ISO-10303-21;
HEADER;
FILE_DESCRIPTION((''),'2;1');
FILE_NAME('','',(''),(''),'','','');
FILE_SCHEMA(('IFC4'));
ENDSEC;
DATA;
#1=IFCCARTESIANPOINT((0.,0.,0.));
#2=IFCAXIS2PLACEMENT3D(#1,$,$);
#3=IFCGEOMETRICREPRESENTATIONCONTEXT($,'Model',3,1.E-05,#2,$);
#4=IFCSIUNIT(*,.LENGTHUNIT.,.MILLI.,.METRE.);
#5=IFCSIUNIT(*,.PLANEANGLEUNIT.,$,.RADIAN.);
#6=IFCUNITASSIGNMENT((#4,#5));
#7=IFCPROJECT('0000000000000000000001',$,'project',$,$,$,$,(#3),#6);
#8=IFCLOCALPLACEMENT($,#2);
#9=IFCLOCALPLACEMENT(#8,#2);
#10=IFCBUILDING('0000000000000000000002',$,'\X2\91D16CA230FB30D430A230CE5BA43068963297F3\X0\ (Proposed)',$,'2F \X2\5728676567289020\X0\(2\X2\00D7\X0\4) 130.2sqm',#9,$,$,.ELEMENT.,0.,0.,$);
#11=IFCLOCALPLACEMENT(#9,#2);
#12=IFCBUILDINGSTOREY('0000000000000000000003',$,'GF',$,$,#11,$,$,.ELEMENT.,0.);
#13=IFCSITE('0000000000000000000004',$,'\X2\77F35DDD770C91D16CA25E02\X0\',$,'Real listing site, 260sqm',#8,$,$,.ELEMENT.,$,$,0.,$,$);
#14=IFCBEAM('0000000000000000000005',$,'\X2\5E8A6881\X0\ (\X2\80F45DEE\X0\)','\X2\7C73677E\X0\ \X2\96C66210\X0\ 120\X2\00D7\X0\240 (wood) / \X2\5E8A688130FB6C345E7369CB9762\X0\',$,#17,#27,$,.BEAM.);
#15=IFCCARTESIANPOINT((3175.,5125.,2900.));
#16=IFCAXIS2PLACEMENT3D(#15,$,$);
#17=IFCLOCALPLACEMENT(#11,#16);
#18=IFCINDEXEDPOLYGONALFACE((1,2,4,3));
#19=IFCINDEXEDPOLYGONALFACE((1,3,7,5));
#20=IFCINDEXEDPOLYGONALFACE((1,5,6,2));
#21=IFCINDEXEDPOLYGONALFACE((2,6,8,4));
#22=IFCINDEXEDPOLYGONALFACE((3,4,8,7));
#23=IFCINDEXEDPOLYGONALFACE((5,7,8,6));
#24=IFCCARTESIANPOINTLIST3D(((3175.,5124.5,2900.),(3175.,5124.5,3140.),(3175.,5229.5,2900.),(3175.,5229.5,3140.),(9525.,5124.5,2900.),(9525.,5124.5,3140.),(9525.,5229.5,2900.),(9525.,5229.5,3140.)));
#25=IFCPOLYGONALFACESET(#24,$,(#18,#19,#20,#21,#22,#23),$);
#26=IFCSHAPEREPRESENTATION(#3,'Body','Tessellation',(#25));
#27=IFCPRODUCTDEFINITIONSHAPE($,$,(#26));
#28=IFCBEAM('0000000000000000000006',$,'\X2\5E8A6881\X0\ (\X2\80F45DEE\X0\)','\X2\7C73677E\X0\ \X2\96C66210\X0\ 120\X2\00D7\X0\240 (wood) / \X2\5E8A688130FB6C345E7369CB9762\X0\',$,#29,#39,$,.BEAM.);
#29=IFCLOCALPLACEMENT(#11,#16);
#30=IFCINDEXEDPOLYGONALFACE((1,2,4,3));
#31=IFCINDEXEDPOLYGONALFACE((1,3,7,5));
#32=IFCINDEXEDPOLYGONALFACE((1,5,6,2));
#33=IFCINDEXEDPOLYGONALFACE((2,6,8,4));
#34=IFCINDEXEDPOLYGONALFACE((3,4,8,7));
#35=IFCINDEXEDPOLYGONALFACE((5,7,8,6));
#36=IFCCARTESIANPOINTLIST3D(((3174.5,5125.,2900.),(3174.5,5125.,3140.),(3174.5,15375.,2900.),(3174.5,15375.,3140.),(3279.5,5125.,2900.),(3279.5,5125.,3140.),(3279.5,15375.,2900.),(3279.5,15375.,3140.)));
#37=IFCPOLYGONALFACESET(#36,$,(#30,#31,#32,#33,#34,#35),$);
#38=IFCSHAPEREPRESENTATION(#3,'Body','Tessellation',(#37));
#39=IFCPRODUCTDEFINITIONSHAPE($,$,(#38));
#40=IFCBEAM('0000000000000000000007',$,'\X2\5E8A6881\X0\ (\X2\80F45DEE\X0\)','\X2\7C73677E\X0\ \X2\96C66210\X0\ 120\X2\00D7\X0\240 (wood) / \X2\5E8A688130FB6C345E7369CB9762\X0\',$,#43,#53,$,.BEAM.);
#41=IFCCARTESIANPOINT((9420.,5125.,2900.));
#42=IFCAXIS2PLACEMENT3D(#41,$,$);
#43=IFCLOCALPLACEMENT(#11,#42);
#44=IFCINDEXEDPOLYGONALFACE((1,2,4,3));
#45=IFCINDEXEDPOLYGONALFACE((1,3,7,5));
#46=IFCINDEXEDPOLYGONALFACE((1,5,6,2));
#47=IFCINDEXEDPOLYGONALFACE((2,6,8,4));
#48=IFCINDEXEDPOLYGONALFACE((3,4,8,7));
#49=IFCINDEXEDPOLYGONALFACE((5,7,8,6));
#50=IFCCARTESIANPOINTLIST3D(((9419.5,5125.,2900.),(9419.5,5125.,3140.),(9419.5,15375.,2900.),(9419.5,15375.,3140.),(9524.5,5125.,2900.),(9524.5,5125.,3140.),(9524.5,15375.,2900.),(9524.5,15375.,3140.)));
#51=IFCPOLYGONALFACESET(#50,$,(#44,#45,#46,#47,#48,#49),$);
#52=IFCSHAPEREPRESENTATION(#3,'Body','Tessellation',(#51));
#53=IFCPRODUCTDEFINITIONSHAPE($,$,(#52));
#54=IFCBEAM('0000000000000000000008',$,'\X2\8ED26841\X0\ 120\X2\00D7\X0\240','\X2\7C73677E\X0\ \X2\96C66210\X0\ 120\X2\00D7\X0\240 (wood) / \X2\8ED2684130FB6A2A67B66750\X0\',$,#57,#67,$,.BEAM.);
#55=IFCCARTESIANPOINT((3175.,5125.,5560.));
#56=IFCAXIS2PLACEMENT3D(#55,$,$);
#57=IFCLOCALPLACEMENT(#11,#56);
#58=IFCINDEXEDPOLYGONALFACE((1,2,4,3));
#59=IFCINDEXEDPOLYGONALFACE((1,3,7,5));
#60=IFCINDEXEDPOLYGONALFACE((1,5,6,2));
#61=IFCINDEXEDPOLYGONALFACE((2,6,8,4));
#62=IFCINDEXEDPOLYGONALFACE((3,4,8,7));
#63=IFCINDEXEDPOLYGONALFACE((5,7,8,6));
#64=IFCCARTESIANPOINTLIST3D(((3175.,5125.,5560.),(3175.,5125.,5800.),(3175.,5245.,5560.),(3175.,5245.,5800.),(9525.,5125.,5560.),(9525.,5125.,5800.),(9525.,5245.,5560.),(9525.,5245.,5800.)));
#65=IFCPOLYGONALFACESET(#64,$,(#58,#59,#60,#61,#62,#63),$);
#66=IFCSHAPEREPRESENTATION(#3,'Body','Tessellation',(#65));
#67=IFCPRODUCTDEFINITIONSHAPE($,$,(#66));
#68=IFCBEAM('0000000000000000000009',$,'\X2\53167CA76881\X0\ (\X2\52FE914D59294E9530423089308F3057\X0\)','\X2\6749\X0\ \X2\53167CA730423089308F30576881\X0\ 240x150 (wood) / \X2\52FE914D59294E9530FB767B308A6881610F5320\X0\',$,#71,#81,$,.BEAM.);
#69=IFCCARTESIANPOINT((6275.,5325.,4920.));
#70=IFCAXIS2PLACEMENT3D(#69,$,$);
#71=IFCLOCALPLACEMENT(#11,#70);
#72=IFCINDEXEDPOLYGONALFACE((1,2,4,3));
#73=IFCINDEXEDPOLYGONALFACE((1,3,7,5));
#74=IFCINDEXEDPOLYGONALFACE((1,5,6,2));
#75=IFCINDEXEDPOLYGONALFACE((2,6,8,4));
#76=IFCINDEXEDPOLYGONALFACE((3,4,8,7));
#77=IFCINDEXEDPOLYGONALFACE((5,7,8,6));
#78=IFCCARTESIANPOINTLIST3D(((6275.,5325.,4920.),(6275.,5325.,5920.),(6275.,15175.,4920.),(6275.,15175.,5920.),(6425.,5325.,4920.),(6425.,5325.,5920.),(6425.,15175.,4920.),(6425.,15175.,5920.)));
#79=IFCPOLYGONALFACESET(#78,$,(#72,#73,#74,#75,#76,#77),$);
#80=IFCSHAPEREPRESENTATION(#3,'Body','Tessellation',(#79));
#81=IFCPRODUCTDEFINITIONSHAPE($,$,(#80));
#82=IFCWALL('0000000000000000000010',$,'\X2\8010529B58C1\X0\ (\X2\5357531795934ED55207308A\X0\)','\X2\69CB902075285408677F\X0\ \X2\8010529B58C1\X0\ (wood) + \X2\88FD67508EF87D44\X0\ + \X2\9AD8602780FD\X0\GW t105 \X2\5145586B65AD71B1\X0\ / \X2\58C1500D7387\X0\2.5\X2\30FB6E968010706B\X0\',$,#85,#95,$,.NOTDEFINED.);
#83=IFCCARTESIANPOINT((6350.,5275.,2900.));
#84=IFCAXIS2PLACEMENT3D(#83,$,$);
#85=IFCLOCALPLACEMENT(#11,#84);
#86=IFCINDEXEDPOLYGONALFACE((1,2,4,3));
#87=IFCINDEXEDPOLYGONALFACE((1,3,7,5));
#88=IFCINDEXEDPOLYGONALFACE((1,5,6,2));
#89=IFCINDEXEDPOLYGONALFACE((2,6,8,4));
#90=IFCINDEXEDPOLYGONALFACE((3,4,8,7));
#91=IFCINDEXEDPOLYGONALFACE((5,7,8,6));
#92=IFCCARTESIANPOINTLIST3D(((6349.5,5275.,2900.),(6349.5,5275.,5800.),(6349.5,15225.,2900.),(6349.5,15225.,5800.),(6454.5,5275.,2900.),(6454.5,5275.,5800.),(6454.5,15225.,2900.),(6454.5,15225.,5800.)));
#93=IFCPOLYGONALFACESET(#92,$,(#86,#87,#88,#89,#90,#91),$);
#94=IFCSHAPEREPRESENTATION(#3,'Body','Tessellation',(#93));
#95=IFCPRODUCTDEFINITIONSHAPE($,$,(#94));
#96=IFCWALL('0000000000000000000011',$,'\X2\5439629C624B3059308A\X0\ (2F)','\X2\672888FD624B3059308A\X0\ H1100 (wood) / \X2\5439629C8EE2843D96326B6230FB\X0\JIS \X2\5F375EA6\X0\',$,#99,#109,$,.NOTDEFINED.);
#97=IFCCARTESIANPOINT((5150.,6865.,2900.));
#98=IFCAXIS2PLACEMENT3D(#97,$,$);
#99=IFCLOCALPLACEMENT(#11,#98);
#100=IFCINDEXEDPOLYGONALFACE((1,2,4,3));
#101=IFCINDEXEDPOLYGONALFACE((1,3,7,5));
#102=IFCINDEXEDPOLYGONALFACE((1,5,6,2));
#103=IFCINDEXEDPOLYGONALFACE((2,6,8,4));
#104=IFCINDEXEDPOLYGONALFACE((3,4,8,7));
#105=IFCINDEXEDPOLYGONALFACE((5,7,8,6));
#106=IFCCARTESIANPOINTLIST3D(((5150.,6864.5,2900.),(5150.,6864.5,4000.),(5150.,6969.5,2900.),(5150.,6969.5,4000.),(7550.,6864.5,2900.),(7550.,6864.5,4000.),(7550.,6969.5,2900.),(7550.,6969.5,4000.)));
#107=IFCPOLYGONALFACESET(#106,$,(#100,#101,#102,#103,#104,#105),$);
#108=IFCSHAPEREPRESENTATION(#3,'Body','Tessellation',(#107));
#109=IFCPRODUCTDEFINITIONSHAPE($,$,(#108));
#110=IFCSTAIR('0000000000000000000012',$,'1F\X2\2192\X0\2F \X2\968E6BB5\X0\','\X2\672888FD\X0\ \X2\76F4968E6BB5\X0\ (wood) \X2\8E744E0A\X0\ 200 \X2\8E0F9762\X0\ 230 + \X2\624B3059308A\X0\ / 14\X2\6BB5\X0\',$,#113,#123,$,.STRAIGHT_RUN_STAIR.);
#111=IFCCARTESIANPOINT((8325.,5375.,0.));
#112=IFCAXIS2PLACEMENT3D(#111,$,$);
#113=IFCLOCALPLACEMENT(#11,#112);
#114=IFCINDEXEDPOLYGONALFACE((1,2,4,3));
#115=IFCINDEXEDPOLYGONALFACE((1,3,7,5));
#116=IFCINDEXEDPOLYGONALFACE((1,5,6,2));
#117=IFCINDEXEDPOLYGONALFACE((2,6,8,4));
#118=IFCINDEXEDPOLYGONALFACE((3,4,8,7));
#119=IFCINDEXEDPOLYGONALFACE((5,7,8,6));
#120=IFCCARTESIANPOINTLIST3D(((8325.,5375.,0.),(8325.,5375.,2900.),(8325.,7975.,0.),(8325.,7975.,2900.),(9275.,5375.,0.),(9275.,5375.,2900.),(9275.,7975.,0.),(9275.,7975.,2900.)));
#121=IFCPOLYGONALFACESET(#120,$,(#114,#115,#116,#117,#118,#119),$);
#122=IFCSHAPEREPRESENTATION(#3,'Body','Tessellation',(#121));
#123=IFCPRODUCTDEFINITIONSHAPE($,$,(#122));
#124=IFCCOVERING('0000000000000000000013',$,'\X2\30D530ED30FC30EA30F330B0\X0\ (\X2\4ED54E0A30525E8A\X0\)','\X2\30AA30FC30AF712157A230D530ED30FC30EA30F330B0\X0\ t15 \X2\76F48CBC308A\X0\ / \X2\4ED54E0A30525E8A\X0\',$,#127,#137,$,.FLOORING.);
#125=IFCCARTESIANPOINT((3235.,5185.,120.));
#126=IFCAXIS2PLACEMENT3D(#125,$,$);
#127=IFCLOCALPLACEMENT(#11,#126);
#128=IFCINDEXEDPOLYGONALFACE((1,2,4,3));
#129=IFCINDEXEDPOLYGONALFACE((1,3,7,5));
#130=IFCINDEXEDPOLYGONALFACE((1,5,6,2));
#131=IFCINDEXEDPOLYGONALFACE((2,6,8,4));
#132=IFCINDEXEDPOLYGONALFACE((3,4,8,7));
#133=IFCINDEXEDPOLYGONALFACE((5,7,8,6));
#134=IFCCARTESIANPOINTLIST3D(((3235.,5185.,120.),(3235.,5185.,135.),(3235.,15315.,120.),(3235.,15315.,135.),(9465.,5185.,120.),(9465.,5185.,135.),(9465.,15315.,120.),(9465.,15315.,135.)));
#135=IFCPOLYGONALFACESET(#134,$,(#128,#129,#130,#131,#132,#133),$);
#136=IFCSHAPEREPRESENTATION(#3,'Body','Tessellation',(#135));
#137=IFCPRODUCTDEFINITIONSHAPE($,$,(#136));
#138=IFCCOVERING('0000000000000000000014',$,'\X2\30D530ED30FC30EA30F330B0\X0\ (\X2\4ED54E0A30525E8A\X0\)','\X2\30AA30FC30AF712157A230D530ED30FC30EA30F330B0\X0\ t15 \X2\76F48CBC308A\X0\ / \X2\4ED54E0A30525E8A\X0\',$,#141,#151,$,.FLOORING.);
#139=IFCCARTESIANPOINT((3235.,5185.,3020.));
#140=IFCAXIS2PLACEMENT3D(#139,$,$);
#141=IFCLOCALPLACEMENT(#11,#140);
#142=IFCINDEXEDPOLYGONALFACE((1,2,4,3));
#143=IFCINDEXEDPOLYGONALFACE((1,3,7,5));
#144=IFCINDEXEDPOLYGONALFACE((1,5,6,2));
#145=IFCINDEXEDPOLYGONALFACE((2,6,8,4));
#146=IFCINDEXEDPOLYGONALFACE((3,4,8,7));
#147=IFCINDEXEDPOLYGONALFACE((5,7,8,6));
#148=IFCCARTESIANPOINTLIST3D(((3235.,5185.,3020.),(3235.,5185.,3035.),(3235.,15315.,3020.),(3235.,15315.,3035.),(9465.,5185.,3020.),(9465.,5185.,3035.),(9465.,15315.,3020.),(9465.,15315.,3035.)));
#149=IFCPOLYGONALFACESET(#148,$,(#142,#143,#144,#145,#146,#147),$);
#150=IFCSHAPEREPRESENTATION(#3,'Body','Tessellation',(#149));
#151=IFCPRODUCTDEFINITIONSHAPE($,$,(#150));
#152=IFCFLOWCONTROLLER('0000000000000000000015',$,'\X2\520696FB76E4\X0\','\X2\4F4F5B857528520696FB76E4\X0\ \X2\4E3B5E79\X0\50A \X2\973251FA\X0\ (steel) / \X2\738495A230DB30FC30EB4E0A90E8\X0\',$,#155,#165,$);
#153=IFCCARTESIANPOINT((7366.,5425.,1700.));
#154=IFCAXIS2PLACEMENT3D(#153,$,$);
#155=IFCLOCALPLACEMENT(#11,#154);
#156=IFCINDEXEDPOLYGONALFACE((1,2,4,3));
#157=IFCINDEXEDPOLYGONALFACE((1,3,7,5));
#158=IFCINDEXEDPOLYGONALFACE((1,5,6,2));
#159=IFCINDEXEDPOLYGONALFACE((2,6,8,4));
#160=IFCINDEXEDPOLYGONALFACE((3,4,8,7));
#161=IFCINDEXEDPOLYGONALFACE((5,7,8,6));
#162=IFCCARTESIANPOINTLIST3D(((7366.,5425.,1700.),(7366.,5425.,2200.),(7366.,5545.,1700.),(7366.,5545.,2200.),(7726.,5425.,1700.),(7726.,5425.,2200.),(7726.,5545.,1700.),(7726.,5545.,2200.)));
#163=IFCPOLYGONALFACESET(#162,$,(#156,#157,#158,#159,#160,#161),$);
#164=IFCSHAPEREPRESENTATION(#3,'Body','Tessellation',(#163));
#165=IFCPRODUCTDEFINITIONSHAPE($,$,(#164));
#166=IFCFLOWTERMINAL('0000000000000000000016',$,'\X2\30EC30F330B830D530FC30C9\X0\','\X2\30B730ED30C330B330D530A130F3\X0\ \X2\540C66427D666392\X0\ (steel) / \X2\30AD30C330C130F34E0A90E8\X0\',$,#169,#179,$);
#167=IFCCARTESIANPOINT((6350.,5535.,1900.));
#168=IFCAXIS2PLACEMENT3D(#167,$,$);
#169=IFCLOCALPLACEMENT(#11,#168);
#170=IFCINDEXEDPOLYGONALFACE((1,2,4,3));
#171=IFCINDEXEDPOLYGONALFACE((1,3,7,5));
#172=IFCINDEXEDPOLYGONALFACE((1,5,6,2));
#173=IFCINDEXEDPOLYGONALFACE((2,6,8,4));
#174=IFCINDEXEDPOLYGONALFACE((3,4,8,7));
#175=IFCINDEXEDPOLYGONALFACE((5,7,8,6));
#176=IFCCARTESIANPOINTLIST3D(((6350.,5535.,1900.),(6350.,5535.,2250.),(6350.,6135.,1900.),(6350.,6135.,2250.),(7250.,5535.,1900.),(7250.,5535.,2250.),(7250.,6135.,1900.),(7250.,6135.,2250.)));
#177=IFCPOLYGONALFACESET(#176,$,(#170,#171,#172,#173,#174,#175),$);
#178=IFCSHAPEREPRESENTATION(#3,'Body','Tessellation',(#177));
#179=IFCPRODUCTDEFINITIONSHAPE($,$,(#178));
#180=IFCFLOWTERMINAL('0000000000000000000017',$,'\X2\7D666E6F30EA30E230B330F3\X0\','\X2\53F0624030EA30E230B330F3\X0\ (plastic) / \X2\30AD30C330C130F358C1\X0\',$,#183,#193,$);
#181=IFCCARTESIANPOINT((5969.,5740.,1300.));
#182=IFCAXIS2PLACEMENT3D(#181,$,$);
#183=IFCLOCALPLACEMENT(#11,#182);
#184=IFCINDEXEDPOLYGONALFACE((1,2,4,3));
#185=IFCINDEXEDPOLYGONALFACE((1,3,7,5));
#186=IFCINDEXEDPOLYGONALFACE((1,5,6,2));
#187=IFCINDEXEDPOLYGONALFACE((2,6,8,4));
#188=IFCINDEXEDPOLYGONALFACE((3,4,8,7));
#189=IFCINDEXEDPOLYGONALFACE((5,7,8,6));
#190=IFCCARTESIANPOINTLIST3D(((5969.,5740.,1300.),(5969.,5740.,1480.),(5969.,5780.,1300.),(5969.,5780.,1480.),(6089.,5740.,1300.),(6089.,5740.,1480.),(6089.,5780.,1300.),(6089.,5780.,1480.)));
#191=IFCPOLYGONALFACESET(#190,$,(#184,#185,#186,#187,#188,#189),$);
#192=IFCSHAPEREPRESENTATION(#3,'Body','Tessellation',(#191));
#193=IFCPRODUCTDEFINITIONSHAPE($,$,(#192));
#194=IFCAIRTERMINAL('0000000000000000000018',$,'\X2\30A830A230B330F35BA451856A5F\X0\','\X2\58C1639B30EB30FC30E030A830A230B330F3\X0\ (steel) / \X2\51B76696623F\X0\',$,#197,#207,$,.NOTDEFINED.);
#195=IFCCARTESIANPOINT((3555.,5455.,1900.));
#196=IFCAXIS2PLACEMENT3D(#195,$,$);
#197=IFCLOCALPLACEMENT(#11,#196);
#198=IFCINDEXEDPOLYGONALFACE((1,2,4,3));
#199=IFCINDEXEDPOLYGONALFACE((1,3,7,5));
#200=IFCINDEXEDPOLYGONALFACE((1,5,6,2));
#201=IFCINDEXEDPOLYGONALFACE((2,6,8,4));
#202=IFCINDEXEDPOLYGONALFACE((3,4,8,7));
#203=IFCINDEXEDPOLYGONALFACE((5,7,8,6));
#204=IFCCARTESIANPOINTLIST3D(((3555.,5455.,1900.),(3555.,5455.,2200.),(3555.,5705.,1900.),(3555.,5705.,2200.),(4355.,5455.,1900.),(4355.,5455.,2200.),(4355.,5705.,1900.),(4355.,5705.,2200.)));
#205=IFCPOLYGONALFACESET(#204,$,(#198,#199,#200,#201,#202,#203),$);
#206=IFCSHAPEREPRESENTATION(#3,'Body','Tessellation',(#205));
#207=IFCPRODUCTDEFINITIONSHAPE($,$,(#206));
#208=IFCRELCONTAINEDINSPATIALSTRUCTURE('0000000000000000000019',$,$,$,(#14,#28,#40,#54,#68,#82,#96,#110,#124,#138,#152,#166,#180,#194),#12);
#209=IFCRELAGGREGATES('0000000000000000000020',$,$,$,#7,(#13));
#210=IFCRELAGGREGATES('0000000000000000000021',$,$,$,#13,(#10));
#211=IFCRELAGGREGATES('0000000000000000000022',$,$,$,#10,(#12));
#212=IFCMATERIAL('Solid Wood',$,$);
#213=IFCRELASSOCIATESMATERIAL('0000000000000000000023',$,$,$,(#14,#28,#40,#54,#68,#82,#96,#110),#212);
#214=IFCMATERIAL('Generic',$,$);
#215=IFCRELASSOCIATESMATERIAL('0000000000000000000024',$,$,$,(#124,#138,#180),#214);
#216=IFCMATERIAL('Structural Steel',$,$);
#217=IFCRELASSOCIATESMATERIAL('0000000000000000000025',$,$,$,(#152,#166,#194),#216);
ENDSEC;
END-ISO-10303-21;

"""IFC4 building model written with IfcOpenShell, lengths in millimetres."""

from ifc_helpers import new_model, si_unit, frame, frame_2d, origin, place, context, project, spatial, rectangle, extrude, material, element, save


model = new_model("IFC4")

# Units and contexts
model_context = context("Model", 3, precision=1e-05, world=origin())
ifc_project = project(units=[si_unit("LENGTHUNIT", "METRE", prefix="MILLI"), si_unit("PLANEANGLEUNIT", "RADIAN")], contexts=[model_context])

# Site, building, storey
site_placement = place(None, origin())
site = spatial("IfcSite", under=ifc_project, at=site_placement, Name="石川県金沢市", ObjectType="Real listing site, 260sqm", CompositionType="ELEMENT", RefElevation=0.0)
building_placement = place(site_placement, origin())
building = spatial("IfcBuilding", under=site, at=building_placement, Name="金沢・ピアノ室と防音 (Proposed)", ObjectType="2F 在来木造(2×4) 130.2sqm", CompositionType="ELEMENT", ElevationOfRefHeight=0.0, ElevationOfTerrain=0.0)
storey_placement = place(building_placement, origin())
storey = spatial("IfcBuildingStorey", under=building, at=storey_placement, Name="GF", CompositionType="ELEMENT", Elevation=0.0)

# Shared definitions
ifc_material_1 = material(Name="Solid Wood")

# Beams
beam_1_placement = place(storey_placement, frame((3175.0, 5125.0, 2900.0)))
element("IfcBeam", 1, at=beam_1_placement, inside=storey, material=ifc_material_1, Name="床梁 (胴差)", Description="米松 集成 120×240 (wood) / 床梁・水平構面", PredefinedType="BEAM", context=model_context, shape_type="SweptSolid", body=[
    extrude(rectangle(XDim=6350.0, YDim=105.0, at=frame_2d((3175.0, 52.0))), frame((3175.0, 5125.0, 2900.0)), (0.0, 0.0, 1.0), 240.0),
])
beam_2_placement = place(storey_placement, frame((3175.0, 5125.0, 2900.0)))
element("IfcBeam", 2, at=beam_2_placement, inside=storey, material=ifc_material_1, Name="床梁 (胴差)", Description="米松 集成 120×240 (wood) / 床梁・水平構面", PredefinedType="BEAM", context=model_context, shape_type="SweptSolid", body=[
    extrude(rectangle(XDim=105.0, YDim=10250.0, at=frame_2d((52.0, 5125.0))), frame((3175.0, 5125.0, 2900.0)), (0.0, 0.0, 1.0), 240.0),
])
beam_3_placement = place(storey_placement, frame((9420.0, 5125.0, 2900.0)))
element("IfcBeam", 3, at=beam_3_placement, inside=storey, material=ifc_material_1, Name="床梁 (胴差)", Description="米松 集成 120×240 (wood) / 床梁・水平構面", PredefinedType="BEAM", context=model_context, shape_type="SweptSolid", body=[
    extrude(rectangle(XDim=105.0, YDim=10250.0, at=frame_2d((52.0, 5125.0))), frame((9420.0, 5125.0, 2900.0)), (0.0, 0.0, 1.0), 240.0),
])
beam_4_placement = place(storey_placement, frame((3175.0, 5125.0, 5560.0)))
element("IfcBeam", 4, at=beam_4_placement, inside=storey, material=ifc_material_1, Name="軒桁 120×240", Description="米松 集成 120×240 (wood) / 軒桁・横架材", PredefinedType="BEAM", context=model_context, shape_type="SweptSolid", body=[
    extrude(rectangle(XDim=6350.0, YDim=120.0, at=frame_2d((3175.0, 60.0))), frame((3175.0, 5125.0, 5560.0)), (0.0, 0.0, 1.0), 240.0),
])
beam_5_placement = place(storey_placement, frame((6275.0, 5325.0, 4920.0)))
element("IfcBeam", 5, at=beam_5_placement, inside=storey, material=ifc_material_1, Name="化粧梁 (勾配天井あらわし)", Description="杉 化粧あらわし梁 240x150 (wood) / 勾配天井・登り梁意匠", PredefinedType="BEAM", context=model_context, shape_type="SweptSolid", body=[
    extrude(rectangle(XDim=150.0, YDim=9850.0, at=frame_2d((75.0, 4925.0))), frame((6275.0, 5325.0, 4920.0)), (0.0, 0.0, 1.0), 1000.0),
])

# Walls
wall_1_placement = place(storey_placement, frame((6350.0, 5275.0, 2900.0)))
element("IfcWall", 6, at=wall_1_placement, inside=storey, material=ifc_material_1, Name="耐力壁 (南北間仕切り)", Description="構造用合板 耐力壁 (wood) + 製材軸組 + 高性能GW t105 充填断熱 / 壁倍率2.5・準耐火", PredefinedType="NOTDEFINED", context=model_context, shape_type="SweptSolid", body=[
    extrude(rectangle(XDim=105.0, YDim=9950.0, at=frame_2d((52.0, 4975.0))), frame((6350.0, 5275.0, 2900.0)), (0.0, 0.0, 1.0), 2900.0),
])
wall_2_placement = place(storey_placement, frame((5150.0, 6865.0, 2900.0)))
element("IfcWall", 7, at=wall_2_placement, inside=storey, material=ifc_material_1, Name="吹抜手すり (2F)", Description="木製手すり H1100 (wood) / 吹抜転落防止・JIS 強度", PredefinedType="NOTDEFINED", context=model_context, shape_type="SweptSolid", body=[
    extrude(rectangle(XDim=2400.0, YDim=105.0, at=frame_2d((1200.0, 52.0))), frame((5150.0, 6865.0, 2900.0)), (0.0, 0.0, 1.0), 1100.0),
])

# Stair
stair_placement = place(storey_placement, frame((8325.0, 5375.0, 0.0)))
element("IfcStair", 8, at=stair_placement, inside=storey, material=ifc_material_1, Name="1F→2F 階段", Description="木製 直階段 (wood) 蹴上 200 踏面 230 + 手すり / 14段", PredefinedType="STRAIGHT_RUN_STAIR", context=model_context, shape_type="SweptSolid", body=[
    extrude(rectangle(XDim=950.0, YDim=2600.0, at=frame_2d((475.0, 1300.0))), frame((8325.0, 5375.0, 0.0)), (0.0, 0.0, 1.0), 2900.0),
])

# Coverings
ifc_material_2 = material(Name="Generic")
covering_1_placement = place(storey_placement, frame((3235.0, 5185.0, 120.0)))
element("IfcCovering", 9, at=covering_1_placement, inside=storey, material=ifc_material_2, Name="フローリング (仕上げ床)", Description="オーク無垢フローリング t15 直貼り / 仕上げ床", PredefinedType="FLOORING", context=model_context, shape_type="SweptSolid", body=[
    extrude(rectangle(XDim=6230.0, YDim=10130.0, at=frame_2d((3115.0, 5065.0))), frame((3235.0, 5185.0, 120.0)), (0.0, 0.0, 1.0), 15.0),
])
covering_2_placement = place(storey_placement, frame((3235.0, 5185.0, 3020.0)))
element("IfcCovering", 10, at=covering_2_placement, inside=storey, material=ifc_material_2, Name="フローリング (仕上げ床)", Description="オーク無垢フローリング t15 直貼り / 仕上げ床", PredefinedType="FLOORING", context=model_context, shape_type="SweptSolid", body=[
    extrude(rectangle(XDim=6230.0, YDim=10130.0, at=frame_2d((3115.0, 5065.0))), frame((3235.0, 5185.0, 3020.0)), (0.0, 0.0, 1.0), 15.0),
])

# Flow controller
ifc_material_3 = material(Name="Structural Steel")
flow_controller_placement = place(storey_placement, frame((7366.0, 5425.0, 1700.0)))
element("IfcFlowController", 11, at=flow_controller_placement, inside=storey, material=ifc_material_3, Name="分電盤", Description="住宅用分電盤 主幹50A 露出 (steel) / 玄関ホール上部", context=model_context, shape_type="SweptSolid", body=[
    extrude(rectangle(XDim=360.0, YDim=120.0, at=frame_2d((180.0, 60.0))), frame((7366.0, 5425.0, 1700.0)), (0.0, 0.0, 1.0), 500.0),
])

# Flow terminals
flow_terminal_1_placement = place(storey_placement, frame((6350.0, 5535.0, 1900.0)))
element("IfcFlowTerminal", 12, at=flow_terminal_1_placement, inside=storey, material=ifc_material_3, Name="レンジフード", Description="シロッコファン 同時給排 (steel) / キッチン上部", context=model_context, shape_type="SweptSolid", body=[
    extrude(rectangle(XDim=900.0, YDim=600.0, at=frame_2d((450.0, 300.0))), frame((6350.0, 5535.0, 1900.0)), (0.0, 0.0, 1.0), 350.0),
])
flow_terminal_2_placement = place(storey_placement, frame((5969.0, 5740.0, 1300.0)))
element("IfcFlowTerminal", 13, at=flow_terminal_2_placement, inside=storey, material=ifc_material_2, Name="給湯リモコン", Description="台所リモコン (plastic) / キッチン壁", context=model_context, shape_type="SweptSolid", body=[
    extrude(rectangle(XDim=120.0, YDim=40.0, at=frame_2d((60.0, 20.0))), frame((5969.0, 5740.0, 1300.0)), (0.0, 0.0, 1.0), 180.0),
])

# Air terminal
air_terminal_1_placement = place(storey_placement, frame((3555.0, 5455.0, 1900.0)))
element("IfcAirTerminal", 14, at=air_terminal_1_placement, inside=storey, material=ifc_material_3, Name="エアコン室内機", Description="壁掛ルームエアコン (steel) / 冷暖房", PredefinedType="NOTDEFINED", context=model_context, shape_type="SweptSolid", body=[
    extrude(rectangle(XDim=800.0, YDim=250.0, at=frame_2d((400.0, 125.0))), frame((3555.0, 5455.0, 1900.0)), (0.0, 0.0, 1.0), 300.0),
])

save(model, "model.ifc")
